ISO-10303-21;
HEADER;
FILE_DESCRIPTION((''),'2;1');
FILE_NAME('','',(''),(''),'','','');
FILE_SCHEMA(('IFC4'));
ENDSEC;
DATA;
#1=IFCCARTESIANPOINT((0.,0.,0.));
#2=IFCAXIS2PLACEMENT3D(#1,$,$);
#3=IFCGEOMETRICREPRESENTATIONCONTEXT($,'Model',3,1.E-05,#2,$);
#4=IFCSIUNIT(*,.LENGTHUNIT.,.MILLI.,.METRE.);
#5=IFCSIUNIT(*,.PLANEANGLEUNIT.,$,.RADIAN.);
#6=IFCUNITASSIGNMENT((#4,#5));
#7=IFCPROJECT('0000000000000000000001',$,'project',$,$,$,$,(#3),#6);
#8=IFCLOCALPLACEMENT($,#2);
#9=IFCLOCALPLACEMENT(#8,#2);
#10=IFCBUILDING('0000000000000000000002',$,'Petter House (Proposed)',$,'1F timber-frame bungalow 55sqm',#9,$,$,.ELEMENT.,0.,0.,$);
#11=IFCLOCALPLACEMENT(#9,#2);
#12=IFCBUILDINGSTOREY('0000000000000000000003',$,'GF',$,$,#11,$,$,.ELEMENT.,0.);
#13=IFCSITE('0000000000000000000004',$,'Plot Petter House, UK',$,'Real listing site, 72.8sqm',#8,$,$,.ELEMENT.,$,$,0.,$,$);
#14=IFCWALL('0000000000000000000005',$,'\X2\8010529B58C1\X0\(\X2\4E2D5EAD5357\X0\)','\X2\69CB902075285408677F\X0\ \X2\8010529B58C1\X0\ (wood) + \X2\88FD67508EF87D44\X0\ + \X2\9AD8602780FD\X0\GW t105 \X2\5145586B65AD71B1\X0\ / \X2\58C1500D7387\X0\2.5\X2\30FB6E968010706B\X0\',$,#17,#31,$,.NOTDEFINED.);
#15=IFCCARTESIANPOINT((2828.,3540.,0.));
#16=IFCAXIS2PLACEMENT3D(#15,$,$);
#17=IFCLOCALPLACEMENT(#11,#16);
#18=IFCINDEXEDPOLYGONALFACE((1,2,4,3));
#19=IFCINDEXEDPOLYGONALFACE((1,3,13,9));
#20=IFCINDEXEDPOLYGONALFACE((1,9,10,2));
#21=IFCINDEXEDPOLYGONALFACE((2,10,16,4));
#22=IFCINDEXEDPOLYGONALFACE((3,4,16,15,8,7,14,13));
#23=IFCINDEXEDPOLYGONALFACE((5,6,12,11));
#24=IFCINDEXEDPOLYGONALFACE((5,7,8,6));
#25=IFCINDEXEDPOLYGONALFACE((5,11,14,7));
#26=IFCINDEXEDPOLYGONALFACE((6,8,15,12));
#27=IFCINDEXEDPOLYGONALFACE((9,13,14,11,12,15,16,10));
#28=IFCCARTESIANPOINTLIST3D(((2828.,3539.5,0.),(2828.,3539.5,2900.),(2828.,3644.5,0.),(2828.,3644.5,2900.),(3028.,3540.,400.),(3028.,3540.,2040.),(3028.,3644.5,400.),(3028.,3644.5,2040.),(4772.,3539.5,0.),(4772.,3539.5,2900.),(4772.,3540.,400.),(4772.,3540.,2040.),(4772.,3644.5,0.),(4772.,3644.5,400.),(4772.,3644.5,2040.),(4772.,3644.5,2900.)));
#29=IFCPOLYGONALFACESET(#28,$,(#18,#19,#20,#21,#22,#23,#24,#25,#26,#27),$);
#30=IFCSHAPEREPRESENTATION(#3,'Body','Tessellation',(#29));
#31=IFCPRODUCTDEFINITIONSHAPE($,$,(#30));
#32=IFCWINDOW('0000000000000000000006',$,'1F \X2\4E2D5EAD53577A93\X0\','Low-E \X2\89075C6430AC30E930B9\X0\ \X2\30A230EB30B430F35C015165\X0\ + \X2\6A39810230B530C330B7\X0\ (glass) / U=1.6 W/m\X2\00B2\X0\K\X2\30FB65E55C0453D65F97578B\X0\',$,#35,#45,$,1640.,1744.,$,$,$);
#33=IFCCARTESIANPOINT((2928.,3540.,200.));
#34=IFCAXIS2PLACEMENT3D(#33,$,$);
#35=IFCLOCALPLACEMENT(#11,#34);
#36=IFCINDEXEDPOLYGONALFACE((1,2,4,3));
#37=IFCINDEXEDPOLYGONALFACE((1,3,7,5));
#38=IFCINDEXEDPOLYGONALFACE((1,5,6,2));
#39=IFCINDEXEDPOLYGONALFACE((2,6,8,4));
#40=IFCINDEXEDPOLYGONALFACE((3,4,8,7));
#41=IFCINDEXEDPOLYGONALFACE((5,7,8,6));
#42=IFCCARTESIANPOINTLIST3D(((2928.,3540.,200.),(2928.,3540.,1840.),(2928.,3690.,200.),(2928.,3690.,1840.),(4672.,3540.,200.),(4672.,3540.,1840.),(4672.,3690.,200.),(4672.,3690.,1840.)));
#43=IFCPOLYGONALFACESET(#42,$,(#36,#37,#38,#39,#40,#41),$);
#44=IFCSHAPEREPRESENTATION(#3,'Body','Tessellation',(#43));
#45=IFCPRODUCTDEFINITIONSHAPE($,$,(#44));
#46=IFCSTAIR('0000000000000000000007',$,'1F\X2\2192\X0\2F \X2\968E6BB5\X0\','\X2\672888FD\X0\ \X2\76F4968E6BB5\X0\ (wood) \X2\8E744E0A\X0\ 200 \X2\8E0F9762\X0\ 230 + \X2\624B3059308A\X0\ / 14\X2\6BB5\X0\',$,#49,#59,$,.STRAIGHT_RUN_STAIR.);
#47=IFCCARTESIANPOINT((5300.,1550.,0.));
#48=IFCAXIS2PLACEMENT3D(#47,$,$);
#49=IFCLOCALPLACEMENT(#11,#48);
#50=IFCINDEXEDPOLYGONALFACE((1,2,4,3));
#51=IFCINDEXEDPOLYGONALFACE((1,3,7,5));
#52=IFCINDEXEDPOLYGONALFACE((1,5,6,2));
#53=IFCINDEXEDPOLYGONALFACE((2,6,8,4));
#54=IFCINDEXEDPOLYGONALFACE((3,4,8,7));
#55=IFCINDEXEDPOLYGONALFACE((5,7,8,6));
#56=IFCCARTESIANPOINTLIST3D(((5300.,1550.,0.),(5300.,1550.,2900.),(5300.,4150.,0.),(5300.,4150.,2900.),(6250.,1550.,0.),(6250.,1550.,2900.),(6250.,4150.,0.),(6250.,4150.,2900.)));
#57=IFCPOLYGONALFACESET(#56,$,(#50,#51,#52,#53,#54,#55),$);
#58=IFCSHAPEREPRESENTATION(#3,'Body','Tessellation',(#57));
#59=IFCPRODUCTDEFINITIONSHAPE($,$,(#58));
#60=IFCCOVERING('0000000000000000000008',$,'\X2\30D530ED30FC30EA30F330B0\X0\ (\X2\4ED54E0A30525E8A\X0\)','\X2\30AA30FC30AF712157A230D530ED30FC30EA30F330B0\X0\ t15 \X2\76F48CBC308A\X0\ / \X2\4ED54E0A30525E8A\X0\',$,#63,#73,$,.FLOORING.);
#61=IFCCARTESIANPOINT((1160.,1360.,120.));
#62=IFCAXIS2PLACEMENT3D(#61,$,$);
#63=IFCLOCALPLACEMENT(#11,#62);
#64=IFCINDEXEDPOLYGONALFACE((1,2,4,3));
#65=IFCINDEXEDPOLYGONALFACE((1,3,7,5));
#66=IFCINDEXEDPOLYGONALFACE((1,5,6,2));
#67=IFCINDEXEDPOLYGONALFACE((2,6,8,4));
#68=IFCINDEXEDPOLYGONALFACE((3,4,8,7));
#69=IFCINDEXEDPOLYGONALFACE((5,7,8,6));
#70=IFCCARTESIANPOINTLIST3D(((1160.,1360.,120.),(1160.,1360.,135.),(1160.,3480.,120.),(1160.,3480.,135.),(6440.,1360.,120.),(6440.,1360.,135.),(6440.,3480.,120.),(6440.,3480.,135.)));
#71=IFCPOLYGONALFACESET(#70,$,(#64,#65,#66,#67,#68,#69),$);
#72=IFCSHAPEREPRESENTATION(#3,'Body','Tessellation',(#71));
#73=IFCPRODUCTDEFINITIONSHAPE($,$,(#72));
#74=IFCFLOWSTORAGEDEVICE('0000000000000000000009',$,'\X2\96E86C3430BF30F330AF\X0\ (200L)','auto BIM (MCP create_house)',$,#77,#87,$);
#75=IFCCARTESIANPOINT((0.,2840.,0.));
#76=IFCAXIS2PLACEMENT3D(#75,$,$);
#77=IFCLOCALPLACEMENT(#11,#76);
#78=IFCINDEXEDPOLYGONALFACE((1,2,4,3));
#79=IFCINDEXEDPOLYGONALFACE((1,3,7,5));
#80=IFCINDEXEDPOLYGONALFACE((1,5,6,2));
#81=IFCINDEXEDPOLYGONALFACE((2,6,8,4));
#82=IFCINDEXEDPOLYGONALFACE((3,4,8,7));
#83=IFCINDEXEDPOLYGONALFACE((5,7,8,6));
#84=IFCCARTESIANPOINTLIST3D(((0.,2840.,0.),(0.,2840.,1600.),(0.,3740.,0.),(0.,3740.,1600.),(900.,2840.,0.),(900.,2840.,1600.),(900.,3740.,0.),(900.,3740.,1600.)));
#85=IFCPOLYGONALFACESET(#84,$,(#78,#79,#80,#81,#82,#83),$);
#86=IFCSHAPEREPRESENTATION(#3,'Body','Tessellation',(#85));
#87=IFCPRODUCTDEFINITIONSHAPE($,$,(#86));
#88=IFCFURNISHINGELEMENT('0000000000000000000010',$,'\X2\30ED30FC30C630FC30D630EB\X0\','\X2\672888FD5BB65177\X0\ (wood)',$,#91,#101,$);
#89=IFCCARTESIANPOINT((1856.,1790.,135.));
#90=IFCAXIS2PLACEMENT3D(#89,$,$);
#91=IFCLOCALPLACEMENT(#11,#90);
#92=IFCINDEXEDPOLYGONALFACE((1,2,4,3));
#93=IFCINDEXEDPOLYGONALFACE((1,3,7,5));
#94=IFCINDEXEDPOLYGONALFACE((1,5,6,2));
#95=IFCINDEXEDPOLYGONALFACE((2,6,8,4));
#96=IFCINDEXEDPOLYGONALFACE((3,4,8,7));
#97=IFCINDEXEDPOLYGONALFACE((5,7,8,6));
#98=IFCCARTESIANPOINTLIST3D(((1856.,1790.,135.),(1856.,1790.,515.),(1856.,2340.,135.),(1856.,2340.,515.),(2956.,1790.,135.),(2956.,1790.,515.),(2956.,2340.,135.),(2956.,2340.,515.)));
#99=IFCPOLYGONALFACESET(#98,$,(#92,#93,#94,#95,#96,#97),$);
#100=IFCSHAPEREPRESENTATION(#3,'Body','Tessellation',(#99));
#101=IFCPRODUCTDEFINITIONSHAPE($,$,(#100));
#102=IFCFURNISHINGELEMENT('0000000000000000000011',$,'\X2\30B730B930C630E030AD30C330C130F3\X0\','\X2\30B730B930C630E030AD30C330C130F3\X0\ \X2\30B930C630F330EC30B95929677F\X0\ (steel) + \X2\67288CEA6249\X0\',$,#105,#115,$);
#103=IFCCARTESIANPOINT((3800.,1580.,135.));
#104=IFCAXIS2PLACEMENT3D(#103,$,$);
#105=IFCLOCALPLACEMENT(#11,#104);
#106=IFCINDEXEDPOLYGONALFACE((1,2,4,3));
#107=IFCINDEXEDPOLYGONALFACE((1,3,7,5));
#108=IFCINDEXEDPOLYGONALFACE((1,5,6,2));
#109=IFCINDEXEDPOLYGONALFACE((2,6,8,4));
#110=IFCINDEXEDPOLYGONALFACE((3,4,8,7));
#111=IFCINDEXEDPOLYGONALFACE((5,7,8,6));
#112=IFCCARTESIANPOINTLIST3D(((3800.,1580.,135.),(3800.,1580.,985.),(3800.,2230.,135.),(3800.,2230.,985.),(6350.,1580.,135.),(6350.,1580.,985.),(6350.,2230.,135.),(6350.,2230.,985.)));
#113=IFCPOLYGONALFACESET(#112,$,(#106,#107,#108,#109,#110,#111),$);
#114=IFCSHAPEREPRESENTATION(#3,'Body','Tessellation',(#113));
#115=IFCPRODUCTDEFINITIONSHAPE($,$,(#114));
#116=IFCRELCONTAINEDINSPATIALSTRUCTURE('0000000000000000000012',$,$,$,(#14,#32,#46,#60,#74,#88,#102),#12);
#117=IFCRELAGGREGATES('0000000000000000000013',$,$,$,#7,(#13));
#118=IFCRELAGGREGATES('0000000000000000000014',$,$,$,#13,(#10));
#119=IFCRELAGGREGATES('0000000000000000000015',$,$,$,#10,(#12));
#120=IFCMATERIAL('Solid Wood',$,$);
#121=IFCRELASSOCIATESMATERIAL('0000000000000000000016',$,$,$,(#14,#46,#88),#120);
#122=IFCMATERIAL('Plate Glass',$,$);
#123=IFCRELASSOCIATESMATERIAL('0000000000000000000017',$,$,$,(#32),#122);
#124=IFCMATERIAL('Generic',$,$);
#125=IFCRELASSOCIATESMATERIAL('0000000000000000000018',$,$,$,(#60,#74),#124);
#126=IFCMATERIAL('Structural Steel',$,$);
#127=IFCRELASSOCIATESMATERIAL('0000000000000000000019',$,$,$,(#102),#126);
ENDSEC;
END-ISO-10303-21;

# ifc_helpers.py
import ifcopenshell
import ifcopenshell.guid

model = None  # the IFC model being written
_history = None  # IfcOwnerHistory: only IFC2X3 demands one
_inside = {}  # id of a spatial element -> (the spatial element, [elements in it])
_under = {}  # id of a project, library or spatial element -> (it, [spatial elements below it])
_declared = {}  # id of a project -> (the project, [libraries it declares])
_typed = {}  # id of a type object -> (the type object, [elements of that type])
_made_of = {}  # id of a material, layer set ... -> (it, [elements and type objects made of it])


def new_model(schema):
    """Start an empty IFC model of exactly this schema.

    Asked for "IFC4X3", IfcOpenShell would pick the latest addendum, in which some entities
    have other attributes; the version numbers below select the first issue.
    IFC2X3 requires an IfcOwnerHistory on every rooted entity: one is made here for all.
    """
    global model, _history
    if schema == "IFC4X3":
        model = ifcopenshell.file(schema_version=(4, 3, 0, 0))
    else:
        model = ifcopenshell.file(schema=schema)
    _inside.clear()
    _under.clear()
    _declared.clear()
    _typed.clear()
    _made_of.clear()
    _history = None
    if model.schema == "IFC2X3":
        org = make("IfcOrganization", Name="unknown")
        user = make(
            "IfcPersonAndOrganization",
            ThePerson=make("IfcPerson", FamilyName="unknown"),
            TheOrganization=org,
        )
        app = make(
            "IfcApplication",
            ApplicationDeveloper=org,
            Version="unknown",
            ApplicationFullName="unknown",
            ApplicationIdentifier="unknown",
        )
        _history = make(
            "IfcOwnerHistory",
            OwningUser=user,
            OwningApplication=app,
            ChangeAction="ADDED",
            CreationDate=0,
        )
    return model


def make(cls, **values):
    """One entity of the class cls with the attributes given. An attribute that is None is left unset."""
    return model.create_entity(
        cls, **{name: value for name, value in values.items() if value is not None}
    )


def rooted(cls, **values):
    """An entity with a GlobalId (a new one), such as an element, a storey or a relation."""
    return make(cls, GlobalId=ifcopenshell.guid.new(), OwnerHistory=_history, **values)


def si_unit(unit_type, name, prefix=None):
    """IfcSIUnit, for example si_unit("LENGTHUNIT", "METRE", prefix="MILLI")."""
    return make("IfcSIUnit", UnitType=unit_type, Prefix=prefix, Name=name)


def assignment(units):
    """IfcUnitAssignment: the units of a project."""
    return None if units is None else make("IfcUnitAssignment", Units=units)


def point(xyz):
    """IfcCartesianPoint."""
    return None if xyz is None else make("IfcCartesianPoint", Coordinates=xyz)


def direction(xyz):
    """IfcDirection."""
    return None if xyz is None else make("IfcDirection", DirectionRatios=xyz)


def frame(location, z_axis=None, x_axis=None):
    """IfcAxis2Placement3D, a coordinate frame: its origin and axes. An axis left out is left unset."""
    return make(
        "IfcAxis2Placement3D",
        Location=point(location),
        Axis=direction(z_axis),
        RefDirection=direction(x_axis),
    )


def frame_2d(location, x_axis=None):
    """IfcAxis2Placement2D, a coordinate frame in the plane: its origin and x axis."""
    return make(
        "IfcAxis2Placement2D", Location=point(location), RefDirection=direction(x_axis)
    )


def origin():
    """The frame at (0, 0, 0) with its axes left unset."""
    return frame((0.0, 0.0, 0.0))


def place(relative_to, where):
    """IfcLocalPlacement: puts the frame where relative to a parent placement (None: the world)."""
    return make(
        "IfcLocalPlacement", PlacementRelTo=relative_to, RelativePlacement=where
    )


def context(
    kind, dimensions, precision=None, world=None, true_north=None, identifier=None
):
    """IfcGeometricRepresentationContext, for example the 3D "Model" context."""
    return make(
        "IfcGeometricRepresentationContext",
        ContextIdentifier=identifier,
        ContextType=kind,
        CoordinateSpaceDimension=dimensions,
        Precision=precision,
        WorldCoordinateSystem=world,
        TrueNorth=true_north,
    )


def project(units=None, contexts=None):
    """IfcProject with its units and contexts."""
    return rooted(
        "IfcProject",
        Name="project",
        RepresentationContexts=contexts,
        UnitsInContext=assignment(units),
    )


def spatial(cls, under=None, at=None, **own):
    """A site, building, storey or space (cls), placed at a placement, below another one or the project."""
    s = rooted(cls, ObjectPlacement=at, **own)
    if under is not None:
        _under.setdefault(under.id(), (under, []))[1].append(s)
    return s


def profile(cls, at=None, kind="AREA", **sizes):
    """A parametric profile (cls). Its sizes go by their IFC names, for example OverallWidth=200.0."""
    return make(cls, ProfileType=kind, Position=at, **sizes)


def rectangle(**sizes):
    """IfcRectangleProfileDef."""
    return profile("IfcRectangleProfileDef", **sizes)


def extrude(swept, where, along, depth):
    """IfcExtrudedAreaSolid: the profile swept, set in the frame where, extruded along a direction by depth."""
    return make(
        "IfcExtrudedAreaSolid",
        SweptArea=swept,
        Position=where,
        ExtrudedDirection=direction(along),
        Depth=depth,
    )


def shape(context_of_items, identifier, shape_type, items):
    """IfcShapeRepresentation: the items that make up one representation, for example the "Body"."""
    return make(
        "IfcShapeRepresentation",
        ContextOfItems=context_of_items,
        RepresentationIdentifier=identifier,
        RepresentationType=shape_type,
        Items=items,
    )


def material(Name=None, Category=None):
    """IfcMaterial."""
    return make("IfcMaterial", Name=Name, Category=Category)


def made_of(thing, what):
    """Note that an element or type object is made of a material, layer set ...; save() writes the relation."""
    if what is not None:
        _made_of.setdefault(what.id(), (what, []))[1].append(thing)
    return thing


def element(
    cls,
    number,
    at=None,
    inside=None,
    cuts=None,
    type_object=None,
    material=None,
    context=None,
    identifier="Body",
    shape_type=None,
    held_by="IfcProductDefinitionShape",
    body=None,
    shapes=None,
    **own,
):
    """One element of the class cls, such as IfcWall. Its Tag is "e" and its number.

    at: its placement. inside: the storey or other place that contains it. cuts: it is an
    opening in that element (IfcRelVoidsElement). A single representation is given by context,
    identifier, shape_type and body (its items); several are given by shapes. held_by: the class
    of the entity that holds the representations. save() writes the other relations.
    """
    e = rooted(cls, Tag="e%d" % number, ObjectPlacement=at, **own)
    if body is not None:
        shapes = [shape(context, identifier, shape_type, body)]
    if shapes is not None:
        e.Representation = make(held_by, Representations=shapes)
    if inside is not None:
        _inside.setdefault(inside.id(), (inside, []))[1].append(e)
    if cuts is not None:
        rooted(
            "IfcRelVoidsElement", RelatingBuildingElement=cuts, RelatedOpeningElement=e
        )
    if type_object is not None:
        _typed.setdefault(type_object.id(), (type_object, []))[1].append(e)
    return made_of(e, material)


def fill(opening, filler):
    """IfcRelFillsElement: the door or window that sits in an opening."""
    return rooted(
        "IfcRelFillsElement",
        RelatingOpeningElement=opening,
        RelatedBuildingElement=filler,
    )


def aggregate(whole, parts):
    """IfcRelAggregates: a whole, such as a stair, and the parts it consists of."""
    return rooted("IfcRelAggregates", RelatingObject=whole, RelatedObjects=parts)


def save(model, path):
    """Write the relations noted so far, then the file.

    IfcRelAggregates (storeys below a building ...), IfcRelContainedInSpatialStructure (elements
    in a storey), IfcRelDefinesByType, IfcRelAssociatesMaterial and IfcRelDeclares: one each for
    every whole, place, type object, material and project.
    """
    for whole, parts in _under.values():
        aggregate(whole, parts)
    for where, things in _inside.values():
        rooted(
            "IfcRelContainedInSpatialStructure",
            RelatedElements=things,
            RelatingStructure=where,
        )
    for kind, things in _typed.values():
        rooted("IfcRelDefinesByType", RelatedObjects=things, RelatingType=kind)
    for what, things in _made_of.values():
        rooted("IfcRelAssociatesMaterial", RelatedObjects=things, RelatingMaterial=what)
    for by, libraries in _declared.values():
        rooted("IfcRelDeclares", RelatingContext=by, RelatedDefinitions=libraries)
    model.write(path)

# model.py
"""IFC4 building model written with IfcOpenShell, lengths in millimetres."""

from ifc_helpers import new_model, si_unit, frame, frame_2d, origin, place, context, project, spatial, rectangle, extrude, material, element, fill, save


model = new_model("IFC4")

# Units and contexts
model_context = context("Model", 3, precision=1e-05, world=origin())
ifc_project = project(units=[si_unit("LENGTHUNIT", "METRE", prefix="MILLI"), si_unit("PLANEANGLEUNIT", "RADIAN")], contexts=[model_context])

# Site, building, storey
site_placement = place(None, origin())
site = spatial("IfcSite", under=ifc_project, at=site_placement, Name="Plot Petter House, UK", ObjectType="Real listing site, 72.8sqm", CompositionType="ELEMENT", RefElevation=0.0)
building_placement = place(site_placement, origin())
building = spatial("IfcBuilding", under=site, at=building_placement, Name="Petter House (Proposed)", ObjectType="1F timber-frame bungalow 55sqm", CompositionType="ELEMENT", ElevationOfRefHeight=0.0, ElevationOfTerrain=0.0)
storey_placement = place(building_placement, origin())
storey = spatial("IfcBuildingStorey", under=building, at=storey_placement, Name="GF", CompositionType="ELEMENT", Elevation=0.0)

# Shared definitions
ifc_material_1 = material(Name="Solid Wood")

# Shared definitions
ifc_material_2 = material(Name="Plate Glass")

# Wall, opening, window
wall_1_placement = place(storey_placement, frame((2828.0, 3540.0, 0.0)))
wall_1 = element("IfcWall", 1, at=wall_1_placement, inside=storey, material=ifc_material_1, Name="耐力壁(中庭南)", Description="構造用合板 耐力壁 (wood) + 製材軸組 + 高性能GW t105 充填断熱 / 壁倍率2.5・準耐火", PredefinedType="NOTDEFINED", context=model_context, shape_type="SweptSolid", body=[
    extrude(rectangle(XDim=1944.0, YDim=105.0, at=frame_2d((972.0, 52.0))), frame((2828.0, 3540.0, 0.0)), (0.0, 0.0, 1.0), 2900.0),
])
opening_1_placement = place(storey_placement, frame((2928.0, 3540.0, 200.0)))
opening_1 = element("IfcOpeningElement", 2, at=opening_1_placement, cuts=wall_1, PredefinedType="NOTDEFINED", context=model_context, shape_type="SweptSolid", body=[
    extrude(rectangle(XDim=1744.0, YDim=150.0, at=frame_2d((872.0, 75.0))), frame((2928.0, 3540.0, 200.0)), (0.0, 0.0, 1.0), 1640.0),
])
window_1_placement = place(storey_placement, frame((2928.0, 3540.0, 200.0)))
window_1 = element("IfcWindow", 3, at=window_1_placement, inside=storey, material=ifc_material_2, Name="1F 中庭南窓", Description="Low-E 複層ガラス アルゴン封入 + 樹脂サッシ (glass) / U=1.6 W/m²K・日射取得型", OverallHeight=1640.0, OverallWidth=1744.0, context=model_context, shape_type="SweptSolid", body=[
    extrude(rectangle(XDim=1744.0, YDim=150.0, at=frame_2d((872.0, 75.0))), frame((2928.0, 3540.0, 200.0)), (0.0, 0.0, 1.0), 1640.0),
])
fill(opening_1, window_1)

# Stair
stair_placement = place(storey_placement, frame((5300.0, 1550.0, 0.0)))
element("IfcStair", 4, at=stair_placement, inside=storey, material=ifc_material_1, Name="1F→2F 階段", Description="木製 直階段 (wood) 蹴上 200 踏面 230 + 手すり / 14段", PredefinedType="STRAIGHT_RUN_STAIR", context=model_context, shape_type="SweptSolid", body=[
    extrude(rectangle(XDim=950.0, YDim=2600.0, at=frame_2d((475.0, 1300.0))), frame((5300.0, 1550.0, 0.0)), (0.0, 0.0, 1.0), 2900.0),
])

# Covering
ifc_material_3 = material(Name="Generic")
covering_placement = place(storey_placement, frame((1160.0, 1360.0, 120.0)))
element("IfcCovering", 5, at=covering_placement, inside=storey, material=ifc_material_3, Name="フローリング (仕上げ床)", Description="オーク無垢フローリング t15 直貼り / 仕上げ床", PredefinedType="FLOORING", context=model_context, shape_type="SweptSolid", body=[
    extrude(rectangle(XDim=5280.0, YDim=2120.0, at=frame_2d((2640.0, 1060.0))), frame((1160.0, 1360.0, 120.0)), (0.0, 0.0, 1.0), 15.0),
])

# Flow storage device
flow_storage_device_placement = place(storey_placement, frame((0.0, 2840.0, 0.0)))
element("IfcFlowStorageDevice", 6, at=flow_storage_device_placement, inside=storey, material=ifc_material_3, Name="雨水タンク (200L)", Description="auto BIM (MCP create_house)", context=model_context, shape_type="SweptSolid", body=[
    extrude(rectangle(XDim=900.0, YDim=900.0, at=frame_2d((450.0, 450.0))), frame((0.0, 2840.0, 0.0)), (0.0, 0.0, 1.0), 1600.0),
])

# Furnishing elements
furnishing_1_placement = place(storey_placement, frame((1856.0, 1790.0, 135.0)))
element("IfcFurnishingElement", 7, at=furnishing_1_placement, inside=storey, material=ifc_material_1, Name="ローテーブル", Description="木製家具 (wood)", context=model_context, shape_type="SweptSolid", body=[
    extrude(rectangle(XDim=1100.0, YDim=550.0, at=frame_2d((550.0, 275.0))), frame((1856.0, 1790.0, 135.0)), (0.0, 0.0, 1.0), 380.0),
])
ifc_material_4 = material(Name="Structural Steel")
furnishing_2_placement = place(storey_placement, frame((3800.0, 1580.0, 135.0)))
element("IfcFurnishingElement", 8, at=furnishing_2_placement, inside=storey, material=ifc_material_4, Name="システムキッチン", Description="システムキッチン ステンレス天板 (steel) + 木質扉", context=model_context, shape_type="SweptSolid", body=[
    extrude(rectangle(XDim=2550.0, YDim=650.0, at=frame_2d((1275.0, 325.0))), frame((3800.0, 1580.0, 135.0)), (0.0, 0.0, 1.0), 850.0),
])

save(model, "model.ifc")
